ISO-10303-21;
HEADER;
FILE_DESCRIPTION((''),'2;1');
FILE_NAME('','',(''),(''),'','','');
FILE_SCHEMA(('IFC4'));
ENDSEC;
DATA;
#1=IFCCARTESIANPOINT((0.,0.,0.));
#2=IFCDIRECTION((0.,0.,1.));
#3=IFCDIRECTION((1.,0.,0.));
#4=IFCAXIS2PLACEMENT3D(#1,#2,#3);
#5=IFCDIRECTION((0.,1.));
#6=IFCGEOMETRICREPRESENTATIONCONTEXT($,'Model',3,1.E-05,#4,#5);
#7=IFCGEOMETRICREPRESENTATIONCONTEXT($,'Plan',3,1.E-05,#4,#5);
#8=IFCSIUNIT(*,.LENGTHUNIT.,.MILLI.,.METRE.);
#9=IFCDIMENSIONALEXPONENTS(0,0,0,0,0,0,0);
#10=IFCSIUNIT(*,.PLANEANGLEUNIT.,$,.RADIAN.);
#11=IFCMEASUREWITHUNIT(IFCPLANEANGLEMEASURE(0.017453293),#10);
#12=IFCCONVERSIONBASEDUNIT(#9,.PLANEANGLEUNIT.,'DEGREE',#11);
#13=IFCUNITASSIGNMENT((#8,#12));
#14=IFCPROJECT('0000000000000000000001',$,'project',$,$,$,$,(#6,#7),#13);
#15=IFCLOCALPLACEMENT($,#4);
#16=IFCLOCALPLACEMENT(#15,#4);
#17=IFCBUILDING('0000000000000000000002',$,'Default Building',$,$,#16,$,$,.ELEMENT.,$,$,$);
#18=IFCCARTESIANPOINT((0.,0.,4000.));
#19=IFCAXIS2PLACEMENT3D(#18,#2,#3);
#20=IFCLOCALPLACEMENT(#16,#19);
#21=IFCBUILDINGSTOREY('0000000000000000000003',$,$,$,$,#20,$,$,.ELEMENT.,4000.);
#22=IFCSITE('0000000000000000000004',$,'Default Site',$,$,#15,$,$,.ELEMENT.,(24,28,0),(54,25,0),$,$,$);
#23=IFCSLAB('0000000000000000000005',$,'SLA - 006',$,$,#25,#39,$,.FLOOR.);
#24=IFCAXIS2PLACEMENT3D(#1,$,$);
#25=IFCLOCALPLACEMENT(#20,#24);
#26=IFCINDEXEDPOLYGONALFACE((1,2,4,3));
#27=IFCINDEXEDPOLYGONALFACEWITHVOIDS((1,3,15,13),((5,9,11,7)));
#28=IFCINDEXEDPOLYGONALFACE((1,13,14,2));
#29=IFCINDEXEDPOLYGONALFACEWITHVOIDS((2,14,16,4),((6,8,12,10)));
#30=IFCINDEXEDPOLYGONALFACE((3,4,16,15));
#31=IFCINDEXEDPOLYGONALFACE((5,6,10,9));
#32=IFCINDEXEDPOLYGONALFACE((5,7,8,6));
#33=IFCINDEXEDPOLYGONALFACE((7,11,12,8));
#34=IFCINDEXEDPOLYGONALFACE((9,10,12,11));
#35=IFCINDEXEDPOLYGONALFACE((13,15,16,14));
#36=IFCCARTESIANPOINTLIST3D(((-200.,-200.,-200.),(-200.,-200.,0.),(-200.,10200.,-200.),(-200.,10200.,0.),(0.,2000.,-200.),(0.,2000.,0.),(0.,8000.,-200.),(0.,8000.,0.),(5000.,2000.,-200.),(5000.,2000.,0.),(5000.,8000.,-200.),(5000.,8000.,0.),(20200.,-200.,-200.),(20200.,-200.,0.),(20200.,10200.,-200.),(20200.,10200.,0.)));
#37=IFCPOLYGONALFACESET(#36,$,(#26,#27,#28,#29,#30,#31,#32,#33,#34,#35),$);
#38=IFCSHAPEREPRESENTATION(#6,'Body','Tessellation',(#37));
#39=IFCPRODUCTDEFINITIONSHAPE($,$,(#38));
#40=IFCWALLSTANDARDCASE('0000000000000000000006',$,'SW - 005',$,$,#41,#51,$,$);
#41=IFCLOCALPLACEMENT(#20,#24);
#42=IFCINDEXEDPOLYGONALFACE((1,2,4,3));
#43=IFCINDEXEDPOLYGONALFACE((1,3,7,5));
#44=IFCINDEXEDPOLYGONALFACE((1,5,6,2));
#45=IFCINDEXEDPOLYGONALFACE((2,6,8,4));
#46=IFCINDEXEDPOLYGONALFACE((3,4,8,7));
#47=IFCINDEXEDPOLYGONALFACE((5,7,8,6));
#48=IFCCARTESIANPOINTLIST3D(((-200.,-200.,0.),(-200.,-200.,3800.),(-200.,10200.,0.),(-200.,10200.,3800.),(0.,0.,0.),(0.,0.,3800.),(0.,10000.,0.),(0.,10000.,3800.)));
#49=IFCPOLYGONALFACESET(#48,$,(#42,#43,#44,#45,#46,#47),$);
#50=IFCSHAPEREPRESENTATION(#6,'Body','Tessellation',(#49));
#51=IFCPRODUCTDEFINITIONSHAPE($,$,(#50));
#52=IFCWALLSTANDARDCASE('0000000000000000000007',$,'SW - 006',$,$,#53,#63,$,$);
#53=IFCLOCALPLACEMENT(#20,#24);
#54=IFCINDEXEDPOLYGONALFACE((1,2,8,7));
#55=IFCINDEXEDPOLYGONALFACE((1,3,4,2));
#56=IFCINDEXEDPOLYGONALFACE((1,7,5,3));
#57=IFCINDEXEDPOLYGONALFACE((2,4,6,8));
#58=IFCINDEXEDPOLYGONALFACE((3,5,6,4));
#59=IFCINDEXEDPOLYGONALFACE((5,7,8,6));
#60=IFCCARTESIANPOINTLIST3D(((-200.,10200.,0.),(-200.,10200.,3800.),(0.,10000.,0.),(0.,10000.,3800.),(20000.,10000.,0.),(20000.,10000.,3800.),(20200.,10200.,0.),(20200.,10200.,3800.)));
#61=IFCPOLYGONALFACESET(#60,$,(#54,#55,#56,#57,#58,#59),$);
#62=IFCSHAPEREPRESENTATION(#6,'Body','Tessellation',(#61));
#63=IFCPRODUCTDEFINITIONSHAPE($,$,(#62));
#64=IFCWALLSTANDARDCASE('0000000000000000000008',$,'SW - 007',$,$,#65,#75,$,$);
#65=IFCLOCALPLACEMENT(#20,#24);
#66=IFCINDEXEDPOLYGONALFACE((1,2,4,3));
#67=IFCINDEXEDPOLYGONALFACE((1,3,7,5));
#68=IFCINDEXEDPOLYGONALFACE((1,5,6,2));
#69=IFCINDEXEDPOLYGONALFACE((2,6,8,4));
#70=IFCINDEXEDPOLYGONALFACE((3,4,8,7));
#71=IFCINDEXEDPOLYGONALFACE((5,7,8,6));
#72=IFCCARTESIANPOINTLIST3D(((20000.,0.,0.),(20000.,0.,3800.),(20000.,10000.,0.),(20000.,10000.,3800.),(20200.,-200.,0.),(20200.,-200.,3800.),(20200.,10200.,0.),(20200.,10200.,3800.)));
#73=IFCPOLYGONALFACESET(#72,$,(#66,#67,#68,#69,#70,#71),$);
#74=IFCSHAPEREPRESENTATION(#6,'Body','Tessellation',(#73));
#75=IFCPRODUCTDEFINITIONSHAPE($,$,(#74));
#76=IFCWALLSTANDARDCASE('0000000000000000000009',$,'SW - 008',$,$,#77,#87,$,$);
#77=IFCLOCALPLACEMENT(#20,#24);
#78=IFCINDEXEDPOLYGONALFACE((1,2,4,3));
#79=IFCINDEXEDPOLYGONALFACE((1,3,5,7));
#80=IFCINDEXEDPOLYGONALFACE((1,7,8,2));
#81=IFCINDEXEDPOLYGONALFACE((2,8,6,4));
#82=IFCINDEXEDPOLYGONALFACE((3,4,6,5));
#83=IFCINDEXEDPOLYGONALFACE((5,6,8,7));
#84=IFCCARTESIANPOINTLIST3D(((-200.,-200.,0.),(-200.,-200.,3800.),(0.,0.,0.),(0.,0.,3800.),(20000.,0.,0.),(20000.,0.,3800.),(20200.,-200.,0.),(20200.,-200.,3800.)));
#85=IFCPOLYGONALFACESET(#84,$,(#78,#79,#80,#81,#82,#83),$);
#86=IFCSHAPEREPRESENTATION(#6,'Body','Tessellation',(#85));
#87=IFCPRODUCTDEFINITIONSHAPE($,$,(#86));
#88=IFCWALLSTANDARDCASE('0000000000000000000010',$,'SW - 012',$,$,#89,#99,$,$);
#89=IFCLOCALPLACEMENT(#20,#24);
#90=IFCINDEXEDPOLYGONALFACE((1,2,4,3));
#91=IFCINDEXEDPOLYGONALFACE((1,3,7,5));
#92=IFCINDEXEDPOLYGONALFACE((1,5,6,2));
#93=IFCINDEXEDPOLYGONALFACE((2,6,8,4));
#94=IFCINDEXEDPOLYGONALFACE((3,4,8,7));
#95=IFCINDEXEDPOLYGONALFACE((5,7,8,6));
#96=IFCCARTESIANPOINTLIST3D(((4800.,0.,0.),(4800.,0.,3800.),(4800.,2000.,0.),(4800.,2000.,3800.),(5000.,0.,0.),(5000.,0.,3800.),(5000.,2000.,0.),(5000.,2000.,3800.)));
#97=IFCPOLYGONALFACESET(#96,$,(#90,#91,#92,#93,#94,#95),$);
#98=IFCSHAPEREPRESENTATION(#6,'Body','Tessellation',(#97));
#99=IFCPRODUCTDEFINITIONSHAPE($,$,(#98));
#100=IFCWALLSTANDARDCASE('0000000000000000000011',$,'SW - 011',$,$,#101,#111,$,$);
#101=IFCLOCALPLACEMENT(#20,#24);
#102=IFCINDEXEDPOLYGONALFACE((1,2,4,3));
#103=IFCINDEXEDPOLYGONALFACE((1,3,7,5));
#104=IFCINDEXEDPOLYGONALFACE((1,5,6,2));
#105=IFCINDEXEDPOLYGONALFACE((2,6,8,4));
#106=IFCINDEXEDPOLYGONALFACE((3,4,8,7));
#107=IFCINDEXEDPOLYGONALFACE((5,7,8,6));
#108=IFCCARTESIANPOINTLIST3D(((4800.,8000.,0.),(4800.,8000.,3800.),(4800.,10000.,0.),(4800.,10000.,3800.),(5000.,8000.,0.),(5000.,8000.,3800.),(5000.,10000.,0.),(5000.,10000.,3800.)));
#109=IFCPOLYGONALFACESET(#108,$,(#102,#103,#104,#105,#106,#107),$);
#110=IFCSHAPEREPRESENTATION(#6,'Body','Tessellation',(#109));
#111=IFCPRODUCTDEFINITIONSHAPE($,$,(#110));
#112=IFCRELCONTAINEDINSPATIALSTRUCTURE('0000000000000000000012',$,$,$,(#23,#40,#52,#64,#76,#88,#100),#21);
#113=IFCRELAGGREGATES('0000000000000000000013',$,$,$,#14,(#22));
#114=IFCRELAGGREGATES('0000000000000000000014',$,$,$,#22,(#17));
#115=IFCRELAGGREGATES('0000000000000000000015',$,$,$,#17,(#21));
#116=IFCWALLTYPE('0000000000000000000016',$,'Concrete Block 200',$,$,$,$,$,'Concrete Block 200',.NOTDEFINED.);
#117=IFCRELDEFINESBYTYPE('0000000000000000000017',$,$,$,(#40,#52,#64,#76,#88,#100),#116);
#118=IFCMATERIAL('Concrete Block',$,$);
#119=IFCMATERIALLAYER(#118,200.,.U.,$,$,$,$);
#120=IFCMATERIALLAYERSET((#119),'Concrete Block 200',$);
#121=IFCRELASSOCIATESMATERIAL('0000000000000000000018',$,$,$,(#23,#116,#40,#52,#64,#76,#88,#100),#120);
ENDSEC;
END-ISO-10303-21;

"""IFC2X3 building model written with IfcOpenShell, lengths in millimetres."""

from ifc_helpers import new_model, entity, si_unit, converted_unit, direction, frame, origin_with_axes, place, context, project, spatial, polyline, outline, extrude, material, layer, layer_set, layer_usage, type_object, element, save


model = new_model("IFC2X3")

# Units and contexts
model_context = context("Model", 3, precision=1e-05, world=origin_with_axes(), true_north=direction((0.0, 1.0)))
plan_context = context("Plan", 3, precision=1e-05, world=origin_with_axes(), true_north=direction((0.0, 1.0)))
ifc_project = project(units=[si_unit("LENGTHUNIT", "METRE", prefix="MILLI"), converted_unit("PLANEANGLEUNIT", "DEGREE", entity("IfcPlaneAngleMeasure", 0.017453293), si_unit("PLANEANGLEUNIT", "RADIAN"), dimensions=[0, 0, 0, 0, 0, 0, 0])], contexts=[model_context, plan_context])

# Site, building, storey
site_placement = place(None, origin_with_axes())
site = spatial("IfcSite", under=ifc_project, at=site_placement, Name="Default Site", CompositionType="ELEMENT", RefLatitude=(24, 28, 0), RefLongitude=(54, 25, 0))
building_placement = place(site_placement, origin_with_axes())
building = spatial("IfcBuilding", under=site, at=building_placement, Name="Default Building", CompositionType="ELEMENT")
storey_placement = place(building_placement, frame((0.0, 0.0, 4000.0), z_axis=(0.0, 0.0, 1.0), x_axis=(1.0, 0.0, 0.0)))
storey = spatial("IfcBuildingStorey", under=building, at=storey_placement, CompositionType="ELEMENT", Elevation=4000.0)

# Slab, opening
ifc_material = material(Name="Concrete Block")
ifc_layer = layer(ifc_material, 200.0, ventilated="UNKNOWN")
ifc_layer_set = layer_set([ifc_layer], Name="Concrete Block 200")
ifc_layer_usage_1 = layer_usage(ifc_layer_set, "AXIS3", "NEGATIVE", 200.0)
slab_placement = place(storey_placement, frame((-200.0, -200.0, -200.0), z_axis=(0.0, 0.0, 1.0), x_axis=(1.0, 0.0, 0.0)))
slab = element("IfcSlab", 1, at=slab_placement, inside=storey, material=ifc_layer_usage_1, Name="SLA - 006", PredefinedType="FLOOR", context=model_context, shape_type="SweptSolid", body=[
    extrude(outline(polyline([(0.0, 0.0), (20400.0, 0.0), (20400.0, 10400.0), (0.0, 10400.0), (0.0, 0.0)])), origin_with_axes(), (0.0, 0.0, 1.0), 200.0),
])
opening_placement = place(slab_placement, origin_with_axes())
element("IfcOpeningElement", 2, at=opening_placement, cuts=slab, context=model_context, shape_type="SweptSolid", body=[
    extrude(outline(polyline([(5200.0, 2200.0), (200.0, 2200.0), (200.0, 8200.0), (5200.0, 8200.0), (5200.0, 2200.0)])), origin_with_axes(), (0.0, 0.0, 1.0), 200.0),
])

# Walls
ifc_layer_usage_2 = layer_usage(ifc_layer_set, "AXIS2", "POSITIVE", 0.0)
wall_type = type_object("IfcWallType", Name="Concrete Block 200", ElementType="Concrete Block 200", PredefinedType="NOTDEFINED", material=ifc_layer_set)
wall_1_placement = place(storey_placement, frame((0.0, 0.0, 0.0), z_axis=(0.0, 0.0, 1.0), x_axis=(0.0, 1.0, 0.0)))
element("IfcWallStandardCase", 3, at=wall_1_placement, inside=storey, type_object=wall_type, material=ifc_layer_usage_2, Name="SW - 005", context=model_context, shape_type="SweptSolid", body=[
    extrude(outline(polyline([(0.0, 0.0), (10000.0, 0.0), (10200.0, 200.0), (-200.0, 200.0), (0.0, 0.0)])), origin_with_axes(), (0.0, 0.0, 1.0), 3800.0),
])
ifc_layer_usage_3 = layer_usage(ifc_layer_set, "AXIS2", "POSITIVE", 0.0)
wall_2_placement = place(storey_placement, frame((0.0, 10000.0, 0.0), z_axis=(0.0, 0.0, 1.0), x_axis=(1.0, 0.0, 0.0)))
element("IfcWallStandardCase", 4, at=wall_2_placement, inside=storey, type_object=wall_type, material=ifc_layer_usage_3, Name="SW - 006", context=model_context, shape_type="SweptSolid", body=[
    extrude(outline(polyline([(0.0, 0.0), (20000.0, 0.0), (20200.0, 200.0), (-200.0, 200.0), (0.0, 0.0)])), origin_with_axes(), (0.0, 0.0, 1.0), 3800.0),
])
ifc_layer_usage_4 = layer_usage(ifc_layer_set, "AXIS2", "POSITIVE", 0.0)
wall_3_placement = place(storey_placement, frame((20000.0, 10000.0, 0.0), z_axis=(0.0, 0.0, 1.0), x_axis=(0.0, -1.0, 0.0)))
element("IfcWallStandardCase", 5, at=wall_3_placement, inside=storey, type_object=wall_type, material=ifc_layer_usage_4, Name="SW - 007", context=model_context, shape_type="SweptSolid", body=[
    extrude(outline(polyline([(0.0, 0.0), (10000.0, 0.0), (10200.0, 200.0), (-200.0, 200.0), (0.0, 0.0)])), origin_with_axes(), (0.0, 0.0, 1.0), 3800.0),
])
ifc_layer_usage_5 = layer_usage(ifc_layer_set, "AXIS2", "POSITIVE", 0.0)
wall_4_placement = place(storey_placement, frame((20000.0, 0.0, 0.0), z_axis=(0.0, 0.0, 1.0), x_axis=(-1.0, 0.0, 0.0)))
element("IfcWallStandardCase", 6, at=wall_4_placement, inside=storey, type_object=wall_type, material=ifc_layer_usage_5, Name="SW - 008", context=model_context, shape_type="SweptSolid", body=[
    extrude(outline(polyline([(0.0, 0.0), (20000.0, 0.0), (20200.0, 200.0), (-200.0, 200.0), (0.0, 0.0)])), origin_with_axes(), (0.0, 0.0, 1.0), 3800.0),
])
ifc_layer_usage_6 = layer_usage(ifc_layer_set, "AXIS2", "NEGATIVE", 0.0)
wall_5_placement = place(storey_placement, frame((5000.0, 2000.0, 0.0), z_axis=(0.0, 0.0, 1.0), x_axis=(0.0, -1.0, 0.0)))
element("IfcWallStandardCase", 7, at=wall_5_placement, inside=storey, type_object=wall_type, material=ifc_layer_usage_6, Name="SW - 012", context=model_context, shape_type="SweptSolid", body=[
    extrude(outline(polyline([(0.0, -200.0), (2000.0, -200.0), (2000.0, 0.0), (0.0, 0.0), (0.0, -200.0)])), origin_with_axes(), (0.0, 0.0, 1.0), 3800.0),
])
ifc_layer_usage_7 = layer_usage(ifc_layer_set, "AXIS2", "POSITIVE", 0.0)
wall_6_placement = place(storey_placement, frame((5000.0, 8000.0, 0.0), z_axis=(0.0, 0.0, 1.0), x_axis=(0.0, 1.0, 0.0)))
element("IfcWallStandardCase", 8, at=wall_6_placement, inside=storey, type_object=wall_type, material=ifc_layer_usage_7, Name="SW - 011", context=model_context, shape_type="SweptSolid", body=[
    extrude(outline(polyline([(0.0, 0.0), (2000.0, 0.0), (2000.0, 200.0), (0.0, 200.0), (0.0, 0.0)])), origin_with_axes(), (0.0, 0.0, 1.0), 3800.0),
])

save(model, "model.ifc")
